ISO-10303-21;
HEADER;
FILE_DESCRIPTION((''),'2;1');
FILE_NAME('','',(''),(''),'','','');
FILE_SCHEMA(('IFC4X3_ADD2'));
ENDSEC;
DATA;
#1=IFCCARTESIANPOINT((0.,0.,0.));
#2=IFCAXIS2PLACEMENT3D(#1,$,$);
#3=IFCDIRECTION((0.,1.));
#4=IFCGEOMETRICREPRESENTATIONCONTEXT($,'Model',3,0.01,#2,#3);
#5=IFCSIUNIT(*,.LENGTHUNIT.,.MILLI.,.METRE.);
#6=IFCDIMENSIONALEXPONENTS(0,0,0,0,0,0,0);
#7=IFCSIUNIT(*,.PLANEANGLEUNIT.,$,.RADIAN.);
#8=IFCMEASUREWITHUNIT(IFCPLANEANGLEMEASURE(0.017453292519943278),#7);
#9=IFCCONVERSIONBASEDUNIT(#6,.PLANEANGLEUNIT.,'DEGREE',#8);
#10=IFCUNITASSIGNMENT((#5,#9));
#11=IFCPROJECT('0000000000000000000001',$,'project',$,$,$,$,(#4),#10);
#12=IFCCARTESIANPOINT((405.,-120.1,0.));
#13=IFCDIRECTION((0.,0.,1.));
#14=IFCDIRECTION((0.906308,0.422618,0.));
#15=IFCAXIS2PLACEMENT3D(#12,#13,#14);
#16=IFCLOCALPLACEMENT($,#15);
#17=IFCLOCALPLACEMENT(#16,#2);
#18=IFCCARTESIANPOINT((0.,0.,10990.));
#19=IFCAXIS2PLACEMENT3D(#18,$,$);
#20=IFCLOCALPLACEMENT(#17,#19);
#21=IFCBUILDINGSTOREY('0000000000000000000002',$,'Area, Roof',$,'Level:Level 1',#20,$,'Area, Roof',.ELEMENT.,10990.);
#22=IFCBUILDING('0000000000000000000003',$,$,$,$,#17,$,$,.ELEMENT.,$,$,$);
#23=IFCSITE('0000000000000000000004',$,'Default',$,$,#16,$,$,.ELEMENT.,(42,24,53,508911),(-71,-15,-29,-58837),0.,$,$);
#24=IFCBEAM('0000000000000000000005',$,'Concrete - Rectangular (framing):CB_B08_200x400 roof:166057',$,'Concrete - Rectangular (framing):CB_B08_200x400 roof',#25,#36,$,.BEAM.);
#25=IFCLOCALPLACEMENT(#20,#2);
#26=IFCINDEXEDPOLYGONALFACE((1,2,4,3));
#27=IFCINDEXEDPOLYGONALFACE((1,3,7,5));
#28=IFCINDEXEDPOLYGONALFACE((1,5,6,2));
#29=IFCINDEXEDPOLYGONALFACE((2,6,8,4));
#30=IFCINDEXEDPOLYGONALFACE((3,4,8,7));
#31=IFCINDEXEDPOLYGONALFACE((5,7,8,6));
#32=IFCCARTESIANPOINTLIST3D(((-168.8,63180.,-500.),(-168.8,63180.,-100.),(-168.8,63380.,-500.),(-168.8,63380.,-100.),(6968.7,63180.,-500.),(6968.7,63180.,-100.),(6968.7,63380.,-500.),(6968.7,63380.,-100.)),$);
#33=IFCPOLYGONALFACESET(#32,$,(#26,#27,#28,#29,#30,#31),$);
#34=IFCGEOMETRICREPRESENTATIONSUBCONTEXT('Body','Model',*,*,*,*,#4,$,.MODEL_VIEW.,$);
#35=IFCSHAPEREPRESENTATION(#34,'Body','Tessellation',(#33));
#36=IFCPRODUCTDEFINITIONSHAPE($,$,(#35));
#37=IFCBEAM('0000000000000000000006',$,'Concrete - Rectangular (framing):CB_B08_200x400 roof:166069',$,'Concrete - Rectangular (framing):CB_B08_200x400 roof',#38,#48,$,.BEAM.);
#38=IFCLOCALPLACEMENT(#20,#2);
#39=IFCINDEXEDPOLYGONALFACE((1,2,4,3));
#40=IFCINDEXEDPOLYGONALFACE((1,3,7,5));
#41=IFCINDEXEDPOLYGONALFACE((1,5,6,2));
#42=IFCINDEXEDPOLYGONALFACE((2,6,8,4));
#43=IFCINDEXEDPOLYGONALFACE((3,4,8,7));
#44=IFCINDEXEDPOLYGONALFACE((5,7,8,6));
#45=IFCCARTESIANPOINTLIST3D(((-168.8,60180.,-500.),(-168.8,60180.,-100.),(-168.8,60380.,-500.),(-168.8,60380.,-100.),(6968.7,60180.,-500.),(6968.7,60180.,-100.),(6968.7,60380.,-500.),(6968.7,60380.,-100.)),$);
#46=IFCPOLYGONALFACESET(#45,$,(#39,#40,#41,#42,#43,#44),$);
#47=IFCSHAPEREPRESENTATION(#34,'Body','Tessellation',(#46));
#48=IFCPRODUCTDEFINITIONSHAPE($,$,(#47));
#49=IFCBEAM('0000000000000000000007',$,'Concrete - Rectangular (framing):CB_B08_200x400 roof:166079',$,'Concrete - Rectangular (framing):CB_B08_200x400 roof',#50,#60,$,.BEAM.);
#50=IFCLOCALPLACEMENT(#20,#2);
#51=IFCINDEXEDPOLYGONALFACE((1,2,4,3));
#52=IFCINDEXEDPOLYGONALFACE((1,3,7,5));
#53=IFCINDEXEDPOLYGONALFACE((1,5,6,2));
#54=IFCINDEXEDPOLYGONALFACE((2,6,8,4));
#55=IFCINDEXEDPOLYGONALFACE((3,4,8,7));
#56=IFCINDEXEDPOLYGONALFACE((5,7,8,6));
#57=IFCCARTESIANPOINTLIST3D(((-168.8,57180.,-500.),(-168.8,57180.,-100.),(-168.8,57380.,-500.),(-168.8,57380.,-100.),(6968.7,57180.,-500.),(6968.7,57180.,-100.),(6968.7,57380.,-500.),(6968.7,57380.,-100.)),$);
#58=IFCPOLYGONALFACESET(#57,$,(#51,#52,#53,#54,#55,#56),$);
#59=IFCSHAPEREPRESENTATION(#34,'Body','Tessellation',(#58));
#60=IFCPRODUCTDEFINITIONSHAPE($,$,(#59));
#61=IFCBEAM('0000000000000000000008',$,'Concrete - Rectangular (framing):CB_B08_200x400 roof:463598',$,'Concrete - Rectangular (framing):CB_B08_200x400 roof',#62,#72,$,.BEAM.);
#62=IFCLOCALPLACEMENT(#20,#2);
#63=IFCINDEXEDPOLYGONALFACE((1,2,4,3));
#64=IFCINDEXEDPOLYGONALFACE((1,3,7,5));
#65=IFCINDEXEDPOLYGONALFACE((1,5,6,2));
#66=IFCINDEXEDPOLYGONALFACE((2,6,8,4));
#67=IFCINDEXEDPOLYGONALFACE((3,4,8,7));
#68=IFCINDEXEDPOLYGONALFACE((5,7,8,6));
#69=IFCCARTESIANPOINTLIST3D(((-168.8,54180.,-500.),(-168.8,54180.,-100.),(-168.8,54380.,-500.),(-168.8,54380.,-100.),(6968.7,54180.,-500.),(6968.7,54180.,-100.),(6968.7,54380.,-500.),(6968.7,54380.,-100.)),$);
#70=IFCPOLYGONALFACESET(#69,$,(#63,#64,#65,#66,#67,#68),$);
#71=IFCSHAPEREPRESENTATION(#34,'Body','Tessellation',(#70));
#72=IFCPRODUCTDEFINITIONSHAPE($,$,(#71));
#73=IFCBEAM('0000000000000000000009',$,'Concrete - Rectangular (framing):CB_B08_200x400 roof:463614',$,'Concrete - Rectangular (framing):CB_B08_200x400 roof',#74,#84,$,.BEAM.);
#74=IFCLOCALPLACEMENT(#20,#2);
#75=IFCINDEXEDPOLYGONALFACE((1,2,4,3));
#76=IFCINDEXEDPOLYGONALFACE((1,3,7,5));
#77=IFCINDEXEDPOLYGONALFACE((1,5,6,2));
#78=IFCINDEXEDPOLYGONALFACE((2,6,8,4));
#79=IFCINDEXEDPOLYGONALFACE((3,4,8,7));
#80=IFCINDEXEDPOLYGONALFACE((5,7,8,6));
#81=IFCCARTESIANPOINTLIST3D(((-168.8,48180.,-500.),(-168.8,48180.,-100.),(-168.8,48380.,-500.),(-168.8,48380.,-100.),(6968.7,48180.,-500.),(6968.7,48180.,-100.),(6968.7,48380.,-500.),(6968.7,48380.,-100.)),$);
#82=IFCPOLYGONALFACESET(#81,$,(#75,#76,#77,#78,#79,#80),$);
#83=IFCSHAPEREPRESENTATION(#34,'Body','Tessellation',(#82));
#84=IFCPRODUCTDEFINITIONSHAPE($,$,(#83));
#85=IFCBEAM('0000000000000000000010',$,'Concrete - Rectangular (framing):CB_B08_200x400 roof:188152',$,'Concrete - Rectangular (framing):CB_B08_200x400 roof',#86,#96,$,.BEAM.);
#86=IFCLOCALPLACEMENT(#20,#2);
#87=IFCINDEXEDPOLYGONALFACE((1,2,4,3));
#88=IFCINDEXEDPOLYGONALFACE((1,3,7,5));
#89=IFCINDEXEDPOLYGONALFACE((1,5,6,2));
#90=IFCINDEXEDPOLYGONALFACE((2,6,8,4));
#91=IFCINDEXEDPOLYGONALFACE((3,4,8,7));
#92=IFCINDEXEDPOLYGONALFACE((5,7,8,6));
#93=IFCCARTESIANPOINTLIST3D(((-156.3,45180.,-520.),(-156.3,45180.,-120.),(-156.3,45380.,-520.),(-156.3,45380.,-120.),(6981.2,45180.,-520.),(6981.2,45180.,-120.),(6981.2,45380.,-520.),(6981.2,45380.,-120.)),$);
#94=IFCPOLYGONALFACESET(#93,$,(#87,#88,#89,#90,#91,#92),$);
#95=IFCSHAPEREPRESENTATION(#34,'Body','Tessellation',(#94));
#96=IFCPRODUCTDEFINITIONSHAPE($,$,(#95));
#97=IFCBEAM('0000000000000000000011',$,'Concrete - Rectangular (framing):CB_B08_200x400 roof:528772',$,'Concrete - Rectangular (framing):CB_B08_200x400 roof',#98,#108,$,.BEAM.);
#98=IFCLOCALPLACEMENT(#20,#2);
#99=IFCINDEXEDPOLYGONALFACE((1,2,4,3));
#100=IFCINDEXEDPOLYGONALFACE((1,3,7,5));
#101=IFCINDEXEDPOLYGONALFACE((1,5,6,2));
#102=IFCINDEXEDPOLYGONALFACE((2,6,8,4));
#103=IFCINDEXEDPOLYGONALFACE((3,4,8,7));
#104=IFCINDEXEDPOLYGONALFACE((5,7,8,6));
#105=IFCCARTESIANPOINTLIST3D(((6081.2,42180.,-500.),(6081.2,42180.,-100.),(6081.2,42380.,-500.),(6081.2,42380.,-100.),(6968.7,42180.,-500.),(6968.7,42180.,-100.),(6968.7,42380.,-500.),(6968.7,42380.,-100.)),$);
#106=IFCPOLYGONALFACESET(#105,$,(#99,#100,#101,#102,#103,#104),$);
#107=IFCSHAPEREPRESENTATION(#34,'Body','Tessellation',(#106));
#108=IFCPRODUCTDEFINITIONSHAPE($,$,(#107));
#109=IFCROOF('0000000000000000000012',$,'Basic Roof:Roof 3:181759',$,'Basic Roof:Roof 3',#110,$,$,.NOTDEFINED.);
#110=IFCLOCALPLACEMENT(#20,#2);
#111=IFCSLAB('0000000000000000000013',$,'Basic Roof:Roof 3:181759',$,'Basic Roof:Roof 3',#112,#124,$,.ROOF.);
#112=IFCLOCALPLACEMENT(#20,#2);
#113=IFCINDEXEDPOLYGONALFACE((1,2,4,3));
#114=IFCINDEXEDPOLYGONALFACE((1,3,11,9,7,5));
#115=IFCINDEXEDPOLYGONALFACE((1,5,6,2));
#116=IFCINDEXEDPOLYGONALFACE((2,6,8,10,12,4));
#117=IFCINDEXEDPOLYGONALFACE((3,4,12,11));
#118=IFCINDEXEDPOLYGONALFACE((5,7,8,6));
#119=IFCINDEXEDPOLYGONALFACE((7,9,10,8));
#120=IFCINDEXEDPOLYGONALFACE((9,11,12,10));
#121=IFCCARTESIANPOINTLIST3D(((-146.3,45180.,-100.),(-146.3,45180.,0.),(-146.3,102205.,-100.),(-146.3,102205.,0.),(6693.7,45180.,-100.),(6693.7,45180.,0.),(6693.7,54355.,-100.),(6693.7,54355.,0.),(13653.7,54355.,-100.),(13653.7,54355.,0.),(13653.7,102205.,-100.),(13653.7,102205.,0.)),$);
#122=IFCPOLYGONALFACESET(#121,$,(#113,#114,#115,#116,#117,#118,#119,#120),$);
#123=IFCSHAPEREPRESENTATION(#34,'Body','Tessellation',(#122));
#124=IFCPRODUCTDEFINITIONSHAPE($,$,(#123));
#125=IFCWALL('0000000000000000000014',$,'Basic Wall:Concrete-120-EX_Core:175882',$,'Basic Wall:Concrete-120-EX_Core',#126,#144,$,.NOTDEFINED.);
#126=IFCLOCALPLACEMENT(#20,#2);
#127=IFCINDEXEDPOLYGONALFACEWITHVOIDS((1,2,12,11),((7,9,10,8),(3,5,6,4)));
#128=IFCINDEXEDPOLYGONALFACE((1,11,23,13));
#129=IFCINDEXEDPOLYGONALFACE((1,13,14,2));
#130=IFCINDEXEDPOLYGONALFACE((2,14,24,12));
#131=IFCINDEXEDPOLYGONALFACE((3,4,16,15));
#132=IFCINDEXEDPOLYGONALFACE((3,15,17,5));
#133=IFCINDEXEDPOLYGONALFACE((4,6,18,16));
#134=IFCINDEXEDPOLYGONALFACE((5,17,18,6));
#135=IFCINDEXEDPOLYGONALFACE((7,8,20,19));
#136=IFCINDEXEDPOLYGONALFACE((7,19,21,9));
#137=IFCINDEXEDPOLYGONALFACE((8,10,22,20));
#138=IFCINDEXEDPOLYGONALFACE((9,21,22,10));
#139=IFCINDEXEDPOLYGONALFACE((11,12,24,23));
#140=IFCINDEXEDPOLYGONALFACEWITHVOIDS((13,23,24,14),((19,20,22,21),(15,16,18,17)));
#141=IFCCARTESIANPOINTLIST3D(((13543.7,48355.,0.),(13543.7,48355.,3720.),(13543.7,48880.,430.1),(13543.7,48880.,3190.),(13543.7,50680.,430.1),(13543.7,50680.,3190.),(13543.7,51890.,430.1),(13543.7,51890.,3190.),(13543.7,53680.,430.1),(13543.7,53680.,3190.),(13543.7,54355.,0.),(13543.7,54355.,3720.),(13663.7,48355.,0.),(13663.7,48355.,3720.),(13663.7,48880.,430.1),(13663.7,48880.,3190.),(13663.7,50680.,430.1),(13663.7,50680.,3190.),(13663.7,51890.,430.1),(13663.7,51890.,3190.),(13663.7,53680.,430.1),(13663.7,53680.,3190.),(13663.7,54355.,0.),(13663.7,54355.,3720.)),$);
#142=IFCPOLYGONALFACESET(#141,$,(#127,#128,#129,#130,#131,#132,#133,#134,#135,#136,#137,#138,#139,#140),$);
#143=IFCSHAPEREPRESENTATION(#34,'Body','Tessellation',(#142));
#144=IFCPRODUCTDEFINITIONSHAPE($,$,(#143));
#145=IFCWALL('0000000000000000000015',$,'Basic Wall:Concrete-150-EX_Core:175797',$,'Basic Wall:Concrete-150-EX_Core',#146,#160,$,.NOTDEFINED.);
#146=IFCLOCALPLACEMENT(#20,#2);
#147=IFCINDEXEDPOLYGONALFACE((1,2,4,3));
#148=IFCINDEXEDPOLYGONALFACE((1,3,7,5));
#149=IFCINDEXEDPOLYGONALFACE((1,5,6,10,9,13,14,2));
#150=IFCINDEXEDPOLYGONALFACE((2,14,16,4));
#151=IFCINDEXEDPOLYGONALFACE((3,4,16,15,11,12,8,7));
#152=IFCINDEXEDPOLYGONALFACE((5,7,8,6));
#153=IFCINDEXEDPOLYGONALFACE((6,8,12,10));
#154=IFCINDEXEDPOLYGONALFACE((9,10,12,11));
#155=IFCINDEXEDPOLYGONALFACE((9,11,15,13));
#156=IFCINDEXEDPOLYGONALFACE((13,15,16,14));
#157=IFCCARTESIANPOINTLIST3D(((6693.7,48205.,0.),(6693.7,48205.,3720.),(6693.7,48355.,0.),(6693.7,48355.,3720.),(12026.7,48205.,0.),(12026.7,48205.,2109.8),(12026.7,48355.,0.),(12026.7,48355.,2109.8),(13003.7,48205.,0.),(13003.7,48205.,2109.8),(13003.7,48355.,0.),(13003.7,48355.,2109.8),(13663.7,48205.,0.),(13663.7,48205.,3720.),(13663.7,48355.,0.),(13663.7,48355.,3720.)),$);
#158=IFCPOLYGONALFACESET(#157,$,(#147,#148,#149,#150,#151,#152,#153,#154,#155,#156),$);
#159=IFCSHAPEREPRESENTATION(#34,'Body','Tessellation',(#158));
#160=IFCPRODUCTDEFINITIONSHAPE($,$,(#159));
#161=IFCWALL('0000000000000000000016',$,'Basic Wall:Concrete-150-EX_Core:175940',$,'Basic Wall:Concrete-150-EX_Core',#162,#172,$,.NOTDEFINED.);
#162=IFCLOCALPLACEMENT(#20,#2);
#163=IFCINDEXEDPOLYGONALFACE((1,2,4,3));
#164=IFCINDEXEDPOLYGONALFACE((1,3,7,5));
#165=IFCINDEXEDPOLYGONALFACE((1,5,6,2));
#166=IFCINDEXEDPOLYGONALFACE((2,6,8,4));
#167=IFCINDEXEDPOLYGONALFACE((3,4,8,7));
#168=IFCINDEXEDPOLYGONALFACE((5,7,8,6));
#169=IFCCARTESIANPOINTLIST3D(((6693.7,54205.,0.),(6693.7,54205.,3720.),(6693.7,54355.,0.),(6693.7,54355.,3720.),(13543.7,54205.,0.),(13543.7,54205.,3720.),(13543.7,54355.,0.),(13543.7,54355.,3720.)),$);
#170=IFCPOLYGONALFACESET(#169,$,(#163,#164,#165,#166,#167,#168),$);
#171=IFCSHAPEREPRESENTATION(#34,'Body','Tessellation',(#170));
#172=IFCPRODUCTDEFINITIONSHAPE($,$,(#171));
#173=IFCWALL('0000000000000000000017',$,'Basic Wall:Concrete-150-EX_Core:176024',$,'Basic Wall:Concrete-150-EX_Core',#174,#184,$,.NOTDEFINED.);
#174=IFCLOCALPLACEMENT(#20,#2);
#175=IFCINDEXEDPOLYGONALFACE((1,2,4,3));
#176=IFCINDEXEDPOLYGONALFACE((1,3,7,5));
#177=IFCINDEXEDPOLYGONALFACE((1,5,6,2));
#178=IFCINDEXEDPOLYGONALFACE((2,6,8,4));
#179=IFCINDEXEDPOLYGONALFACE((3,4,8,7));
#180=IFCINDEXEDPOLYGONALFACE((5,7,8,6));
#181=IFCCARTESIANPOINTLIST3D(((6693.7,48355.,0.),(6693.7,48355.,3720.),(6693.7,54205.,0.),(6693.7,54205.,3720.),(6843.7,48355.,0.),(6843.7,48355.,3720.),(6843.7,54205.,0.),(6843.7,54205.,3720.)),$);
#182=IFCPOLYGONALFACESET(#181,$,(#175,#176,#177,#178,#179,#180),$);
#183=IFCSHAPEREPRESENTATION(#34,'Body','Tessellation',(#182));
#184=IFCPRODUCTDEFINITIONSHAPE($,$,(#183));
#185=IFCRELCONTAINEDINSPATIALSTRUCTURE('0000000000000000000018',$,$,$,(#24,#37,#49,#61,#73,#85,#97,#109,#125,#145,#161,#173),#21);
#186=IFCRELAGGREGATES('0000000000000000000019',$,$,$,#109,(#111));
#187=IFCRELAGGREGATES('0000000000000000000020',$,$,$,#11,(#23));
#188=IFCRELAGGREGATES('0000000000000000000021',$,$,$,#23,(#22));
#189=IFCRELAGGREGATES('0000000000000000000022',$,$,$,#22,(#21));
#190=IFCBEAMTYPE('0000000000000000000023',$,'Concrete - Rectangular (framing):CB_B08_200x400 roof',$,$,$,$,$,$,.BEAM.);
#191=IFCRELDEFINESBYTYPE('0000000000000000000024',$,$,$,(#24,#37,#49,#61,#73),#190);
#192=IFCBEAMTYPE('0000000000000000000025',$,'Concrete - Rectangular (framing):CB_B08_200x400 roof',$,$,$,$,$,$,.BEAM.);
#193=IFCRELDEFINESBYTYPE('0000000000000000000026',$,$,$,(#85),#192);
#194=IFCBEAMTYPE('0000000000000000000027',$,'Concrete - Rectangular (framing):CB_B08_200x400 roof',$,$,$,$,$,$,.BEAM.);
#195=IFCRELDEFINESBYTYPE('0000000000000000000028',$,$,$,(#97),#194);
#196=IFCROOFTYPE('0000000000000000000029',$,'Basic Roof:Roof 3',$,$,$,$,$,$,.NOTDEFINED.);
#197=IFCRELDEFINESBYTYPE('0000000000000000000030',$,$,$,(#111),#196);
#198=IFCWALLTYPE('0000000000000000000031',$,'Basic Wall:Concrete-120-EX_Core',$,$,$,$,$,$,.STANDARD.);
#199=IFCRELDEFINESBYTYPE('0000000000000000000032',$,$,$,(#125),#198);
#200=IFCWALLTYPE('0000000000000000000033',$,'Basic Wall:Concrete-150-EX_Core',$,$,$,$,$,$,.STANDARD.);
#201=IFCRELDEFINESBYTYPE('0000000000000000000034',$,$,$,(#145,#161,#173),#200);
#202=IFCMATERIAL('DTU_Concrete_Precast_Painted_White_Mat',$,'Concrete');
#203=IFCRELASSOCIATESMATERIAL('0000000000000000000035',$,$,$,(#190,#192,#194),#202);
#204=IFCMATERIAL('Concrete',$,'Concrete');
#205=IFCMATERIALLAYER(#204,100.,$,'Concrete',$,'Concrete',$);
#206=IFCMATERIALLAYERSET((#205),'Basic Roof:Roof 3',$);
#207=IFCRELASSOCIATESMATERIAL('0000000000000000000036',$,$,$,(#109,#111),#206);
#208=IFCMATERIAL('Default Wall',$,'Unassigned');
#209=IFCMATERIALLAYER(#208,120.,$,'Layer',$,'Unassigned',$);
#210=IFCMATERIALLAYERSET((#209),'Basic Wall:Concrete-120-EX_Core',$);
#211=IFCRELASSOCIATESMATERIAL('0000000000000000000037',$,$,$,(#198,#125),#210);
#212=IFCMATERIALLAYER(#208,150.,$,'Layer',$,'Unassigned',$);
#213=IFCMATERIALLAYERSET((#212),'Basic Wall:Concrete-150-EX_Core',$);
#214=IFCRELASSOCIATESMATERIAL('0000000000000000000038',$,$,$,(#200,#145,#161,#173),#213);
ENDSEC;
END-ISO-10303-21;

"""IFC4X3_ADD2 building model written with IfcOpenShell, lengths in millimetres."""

from ifc_helpers import new_model, entity, si_unit, converted_unit, direction, frame, frame_2d, origin, origin_2d_with_axis, place, context, subcontext, project, spatial, polyline, rectangle, outline, extrude, source, transform, mapped, material, layer, layer_set, material_profile, profile_set, type_object, type_shapes, element, aggregate, save


model = new_model("IFC4X3_ADD2")

# Units and contexts
model_context = context("Model", 3, precision=0.01, world=origin(), true_north=direction((0.0, 1.0)))
body_context = subcontext(model_context, "Body", "Model", "MODEL_VIEW")
ifc_project = project(units=[si_unit("LENGTHUNIT", "METRE", prefix="MILLI"), converted_unit("PLANEANGLEUNIT", "DEGREE", entity("IfcPlaneAngleMeasure", 0.017453292519943278), si_unit("PLANEANGLEUNIT", "RADIAN"), dimensions=[0, 0, 0, 0, 0, 0, 0])], contexts=[model_context])

# Site, building, storey
site_placement = place(None, frame((405.0, -120.1, 0.0), z_axis=(0.0, 0.0, 1.0), x_axis=(0.906308, 0.422618, 0.0)))
site = spatial("IfcSite", under=ifc_project, at=site_placement, Name="Default", CompositionType="ELEMENT", RefLatitude=(42, 24, 53, 508911), RefLongitude=(-71, -15, -29, -58837), RefElevation=0.0)
building_placement = place(site_placement, origin())
building = spatial("IfcBuilding", under=site, at=building_placement, CompositionType="ELEMENT")
storey_placement = place(building_placement, frame((0.0, 0.0, 10990.0)))
storey = spatial("IfcBuildingStorey", under=building, at=storey_placement, Name="Area, Roof", ObjectType="Level:Level 1", LongName="Area, Roof", CompositionType="ELEMENT", Elevation=10990.0)

# Beams
ifc_material_1 = material(Name="DTU_Concrete_Precast_Painted_White_Mat", Category="Concrete")
ifc_material_profile_1 = material_profile(ifc_material_1, rectangle(XDim=7137.5, YDim=200.0, at=origin_2d_with_axis()), Name="CB_B08_200x400 roof")
ifc_profile_set_1 = profile_set([ifc_material_profile_1], Name="CB_B08_200x400 roof")
beam_type_1 = type_object("IfcBeamType", Name="Concrete - Rectangular (framing):CB_B08_200x400 roof", PredefinedType="BEAM", material=ifc_profile_set_1)
shared_shape_1 = source(origin(), body_context, "Body", "SweptSolid", [
    extrude(rectangle(XDim=7137.5, YDim=200.0, at=origin_2d_with_axis()), frame((6.3, 0.0, -200.0), z_axis=(0.0, 0.0, 1.0), x_axis=(-1.0, 0.0, 0.0)), (0.0, 0.0, 1.0), 400.0),
])
type_shapes(beam_type_1, [shared_shape_1])
for number, where, z_axis, x_axis, name in (
    (1, (3406.2, 63280.0, -300.0), (0.0, 0.0, 1.0), (-1.0, 0.0, 0.0), "Concrete - Rectangular (framing):CB_B08_200x400 roof:166057"),
    (2, (3406.2, 60280.0, -300.0), (0.0, 0.0, 1.0), (-1.0, 0.0, 0.0), "Concrete - Rectangular (framing):CB_B08_200x400 roof:166069"),
    (3, (3406.2, 57280.0, -300.0), (0.0, 0.0, 1.0), (-1.0, 0.0, 0.0), "Concrete - Rectangular (framing):CB_B08_200x400 roof:166079"),
    (4, (3406.2, 54280.0, -300.0), (0.0, 0.0, 1.0), (-1.0, 0.0, 0.0), "Concrete - Rectangular (framing):CB_B08_200x400 roof:463598"),
    (5, (3406.2, 48280.0, -300.0), (0.0, 0.0, 1.0), (-1.0, 0.0, 0.0), "Concrete - Rectangular (framing):CB_B08_200x400 roof:463614"),
):
    element("IfcBeam", number, at=place(storey_placement, frame(where, z_axis=z_axis, x_axis=x_axis)), inside=storey, type_object=beam_type_1, Name=name, ObjectType="Concrete - Rectangular (framing):CB_B08_200x400 roof", PredefinedType="BEAM", context=body_context, shape_type="MappedRepresentation", body=[
        mapped(shared_shape_1, transform((0.0, 0.0, 0.0), scale=1.0)),
    ])
beam_type_2 = type_object("IfcBeamType", Name="Concrete - Rectangular (framing):CB_B08_200x400 roof", PredefinedType="BEAM", material=ifc_profile_set_1)
shared_shape_2 = source(origin(), body_context, "Body", "SweptSolid", [
    extrude(rectangle(XDim=7137.5, YDim=200.0, at=origin_2d_with_axis()), frame((-6.3, 0.0, -200.0), z_axis=(0.0, 0.0, 1.0), x_axis=(-1.0, 0.0, 0.0)), (0.0, 0.0, 1.0), 400.0),
])
type_shapes(beam_type_2, [shared_shape_2])
beam_1_placement = place(storey_placement, frame((3406.2, 45280.0, -320.0), z_axis=(0.0, 0.0, 1.0), x_axis=(-1.0, 0.0, 0.0)))
element("IfcBeam", 6, at=beam_1_placement, inside=storey, type_object=beam_type_2, Name="Concrete - Rectangular (framing):CB_B08_200x400 roof:188152", ObjectType="Concrete - Rectangular (framing):CB_B08_200x400 roof", PredefinedType="BEAM", context=body_context, shape_type="MappedRepresentation", body=[
    mapped(shared_shape_2, transform((0.0, 0.0, 0.0), scale=1.0)),
])
beam_type_3 = type_object("IfcBeamType", Name="Concrete - Rectangular (framing):CB_B08_200x400 roof", PredefinedType="BEAM", material=ifc_profile_set_1)
shared_shape_3 = source(origin(), body_context, "Body", "SweptSolid", [
    extrude(rectangle(XDim=887.5, YDim=200.0, at=origin_2d_with_axis()), frame((443.8, 100.0, 0.0), z_axis=(0.0, 0.0, 1.0), x_axis=(-1.0, 0.0, 0.0)), (0.0, 0.0, 1.0), 400.0),
])
type_shapes(beam_type_3, [shared_shape_3])
beam_2_placement = place(storey_placement, frame((6968.7, 42380.0, -500.0), z_axis=(0.0, 0.0, 1.0), x_axis=(-1.0, 0.0, 0.0)))
element("IfcBeam", 7, at=beam_2_placement, inside=storey, type_object=beam_type_3, Name="Concrete - Rectangular (framing):CB_B08_200x400 roof:528772", ObjectType="Concrete - Rectangular (framing):CB_B08_200x400 roof", PredefinedType="BEAM", context=body_context, shape_type="MappedRepresentation", body=[
    mapped(shared_shape_3, transform((0.0, 0.0, 0.0), scale=1.0)),
])

# Roof, slab
ifc_material_2 = material(Name="Concrete", Category="Concrete")
ifc_layer_1 = layer(ifc_material_2, 100.0, Name="Concrete", Category="Concrete")
ifc_layer_set_1 = layer_set([ifc_layer_1], Name="Basic Roof:Roof 3")
roof_placement = place(storey_placement, frame((-146.3, 45180.0, -100.0)))
roof = element("IfcRoof", 8, at=roof_placement, inside=storey, material=ifc_layer_set_1, Name="Basic Roof:Roof 3:181759", ObjectType="Basic Roof:Roof 3", PredefinedType="NOTDEFINED")
roof_type = type_object("IfcRoofType", Name="Basic Roof:Roof 3", PredefinedType="NOTDEFINED")
slab_placement = place(roof_placement, origin())
slab = element("IfcSlab", 9, at=slab_placement, type_object=roof_type, material=ifc_layer_set_1, Name="Basic Roof:Roof 3:181759", ObjectType="Basic Roof:Roof 3", PredefinedType="ROOF", context=body_context, shape_type="SweptSolid", body=[
    extrude(outline(polyline([(-60.0, -28512.5), (-60.0, -19337.5), (6900.0, -19337.5), (6900.0, 28512.5), (-6900.0, 28512.5), (-6900.0, -28512.5), (-60.0, -28512.5)])), frame((6900.0, 28512.5, 0.0)), (0.0, 0.0, 1.0), 100.0),
])
aggregate(roof, [slab])

# Wall, openings
ifc_material_3 = material(Name="Default Wall", Category="Unassigned")
ifc_layer_2 = layer(ifc_material_3, 120.0, Name="Layer", Category="Unassigned")
ifc_layer_set_2 = layer_set([ifc_layer_2], Name="Basic Wall:Concrete-120-EX_Core")
wall_type_1 = type_object("IfcWallType", Name="Basic Wall:Concrete-120-EX_Core", PredefinedType="STANDARD", material=ifc_layer_set_2)
wall_1_placement = place(storey_placement, frame((13603.7, 48355.0, 0.0), z_axis=(0.0, 0.0, 1.0), x_axis=(0.0, 1.0, 0.0)))
wall_1 = element("IfcWall", 10, at=wall_1_placement, inside=storey, type_object=wall_type_1, material=ifc_layer_set_2, Name="Basic Wall:Concrete-120-EX_Core:175882", ObjectType="Basic Wall:Concrete-120-EX_Core", PredefinedType="NOTDEFINED", context=body_context, shape_type="SweptSolid", body=[
    extrude(rectangle(XDim=6000.0, YDim=120.0, at=frame_2d((3000.0, 0.0), x_axis=(-1.0, 0.0))), origin(), (0.0, 0.0, 1.0), 3720.0),
])
opening_1_placement = place(wall_1_placement, origin())
element("IfcOpeningElement", 11, at=opening_1_placement, cuts=wall_1, PredefinedType="OPENING", context=body_context, shape_type="SweptSolid", body=[
    extrude(rectangle(XDim=2759.9, YDim=1800.0, at=frame_2d((0.0, 0.0), x_axis=(1.0, 0.0))), frame((1425.0, 60.0, 1810.0), z_axis=(0.0, -1.0, 0.0), x_axis=(0.0, 0.0, 1.0)), (0.0, 0.0, 1.0), 120.0),
])
opening_2_placement = place(wall_1_placement, origin())
element("IfcOpeningElement", 12, at=opening_2_placement, cuts=wall_1, PredefinedType="OPENING", context=body_context, shape_type="SweptSolid", body=[
    extrude(rectangle(XDim=2759.9, YDim=1790.0, at=frame_2d((0.0, 0.0), x_axis=(1.0, 0.0))), frame((4430.0, 60.0, 1810.0), z_axis=(0.0, -1.0, 0.0), x_axis=(0.0, 0.0, 1.0)), (0.0, 0.0, 1.0), 120.0),
])

# Wall, opening
ifc_layer_3 = layer(ifc_material_3, 150.0, Name="Layer", Category="Unassigned")
ifc_layer_set_3 = layer_set([ifc_layer_3], Name="Basic Wall:Concrete-150-EX_Core")
wall_type_2 = type_object("IfcWallType", Name="Basic Wall:Concrete-150-EX_Core", PredefinedType="STANDARD", material=ifc_layer_set_3)
wall_2_placement = place(storey_placement, frame((6693.7, 48280.0, 0.0)))
wall_2 = element("IfcWall", 13, at=wall_2_placement, inside=storey, type_object=wall_type_2, material=ifc_layer_set_3, Name="Basic Wall:Concrete-150-EX_Core:175797", ObjectType="Basic Wall:Concrete-150-EX_Core", PredefinedType="NOTDEFINED", context=body_context, shape_type="SweptSolid", body=[
    extrude(rectangle(XDim=6970.0, YDim=150.0, at=frame_2d((3485.0, 0.0), x_axis=(-1.0, 0.0))), origin(), (0.0, 0.0, 1.0), 3720.0),
])
opening_3_placement = place(wall_2_placement, origin())
element("IfcOpeningElement", 14, at=opening_3_placement, cuts=wall_2, PredefinedType="OPENING", context=body_context, shape_type="SweptSolid", body=[
    extrude(rectangle(XDim=2109.8, YDim=977.0, at=frame_2d((0.0, 0.0), x_axis=(0.0, 1.0))), frame((5821.5, 75.0, 1054.9), z_axis=(0.0, -1.0, 0.0), x_axis=(1.0, 0.0, 0.0)), (0.0, 0.0, 1.0), 150.0),
])

# Walls
wall_3_placement = place(storey_placement, frame((13543.7, 54280.0, 0.0), z_axis=(0.0, 0.0, 1.0), x_axis=(-1.0, 0.0, 0.0)))
element("IfcWall", 15, at=wall_3_placement, inside=storey, type_object=wall_type_2, material=ifc_layer_set_3, Name="Basic Wall:Concrete-150-EX_Core:175940", ObjectType="Basic Wall:Concrete-150-EX_Core", PredefinedType="NOTDEFINED", context=body_context, shape_type="SweptSolid", body=[
    extrude(rectangle(XDim=6850.0, YDim=150.0, at=frame_2d((3425.0, 0.0), x_axis=(-1.0, 0.0))), origin(), (0.0, 0.0, 1.0), 3720.0),
])
wall_4_placement = place(storey_placement, frame((6768.7, 54205.0, 0.0), z_axis=(0.0, 0.0, 1.0), x_axis=(0.0, -1.0, 0.0)))
element("IfcWall", 16, at=wall_4_placement, inside=storey, type_object=wall_type_2, material=ifc_layer_set_3, Name="Basic Wall:Concrete-150-EX_Core:176024", ObjectType="Basic Wall:Concrete-150-EX_Core", PredefinedType="NOTDEFINED", context=body_context, shape_type="SweptSolid", body=[
    extrude(rectangle(XDim=5850.0, YDim=150.0, at=frame_2d((2925.0, 0.0), x_axis=(-1.0, 0.0))), origin(), (0.0, 0.0, 1.0), 3720.0),
])

save(model, "model.ifc")
